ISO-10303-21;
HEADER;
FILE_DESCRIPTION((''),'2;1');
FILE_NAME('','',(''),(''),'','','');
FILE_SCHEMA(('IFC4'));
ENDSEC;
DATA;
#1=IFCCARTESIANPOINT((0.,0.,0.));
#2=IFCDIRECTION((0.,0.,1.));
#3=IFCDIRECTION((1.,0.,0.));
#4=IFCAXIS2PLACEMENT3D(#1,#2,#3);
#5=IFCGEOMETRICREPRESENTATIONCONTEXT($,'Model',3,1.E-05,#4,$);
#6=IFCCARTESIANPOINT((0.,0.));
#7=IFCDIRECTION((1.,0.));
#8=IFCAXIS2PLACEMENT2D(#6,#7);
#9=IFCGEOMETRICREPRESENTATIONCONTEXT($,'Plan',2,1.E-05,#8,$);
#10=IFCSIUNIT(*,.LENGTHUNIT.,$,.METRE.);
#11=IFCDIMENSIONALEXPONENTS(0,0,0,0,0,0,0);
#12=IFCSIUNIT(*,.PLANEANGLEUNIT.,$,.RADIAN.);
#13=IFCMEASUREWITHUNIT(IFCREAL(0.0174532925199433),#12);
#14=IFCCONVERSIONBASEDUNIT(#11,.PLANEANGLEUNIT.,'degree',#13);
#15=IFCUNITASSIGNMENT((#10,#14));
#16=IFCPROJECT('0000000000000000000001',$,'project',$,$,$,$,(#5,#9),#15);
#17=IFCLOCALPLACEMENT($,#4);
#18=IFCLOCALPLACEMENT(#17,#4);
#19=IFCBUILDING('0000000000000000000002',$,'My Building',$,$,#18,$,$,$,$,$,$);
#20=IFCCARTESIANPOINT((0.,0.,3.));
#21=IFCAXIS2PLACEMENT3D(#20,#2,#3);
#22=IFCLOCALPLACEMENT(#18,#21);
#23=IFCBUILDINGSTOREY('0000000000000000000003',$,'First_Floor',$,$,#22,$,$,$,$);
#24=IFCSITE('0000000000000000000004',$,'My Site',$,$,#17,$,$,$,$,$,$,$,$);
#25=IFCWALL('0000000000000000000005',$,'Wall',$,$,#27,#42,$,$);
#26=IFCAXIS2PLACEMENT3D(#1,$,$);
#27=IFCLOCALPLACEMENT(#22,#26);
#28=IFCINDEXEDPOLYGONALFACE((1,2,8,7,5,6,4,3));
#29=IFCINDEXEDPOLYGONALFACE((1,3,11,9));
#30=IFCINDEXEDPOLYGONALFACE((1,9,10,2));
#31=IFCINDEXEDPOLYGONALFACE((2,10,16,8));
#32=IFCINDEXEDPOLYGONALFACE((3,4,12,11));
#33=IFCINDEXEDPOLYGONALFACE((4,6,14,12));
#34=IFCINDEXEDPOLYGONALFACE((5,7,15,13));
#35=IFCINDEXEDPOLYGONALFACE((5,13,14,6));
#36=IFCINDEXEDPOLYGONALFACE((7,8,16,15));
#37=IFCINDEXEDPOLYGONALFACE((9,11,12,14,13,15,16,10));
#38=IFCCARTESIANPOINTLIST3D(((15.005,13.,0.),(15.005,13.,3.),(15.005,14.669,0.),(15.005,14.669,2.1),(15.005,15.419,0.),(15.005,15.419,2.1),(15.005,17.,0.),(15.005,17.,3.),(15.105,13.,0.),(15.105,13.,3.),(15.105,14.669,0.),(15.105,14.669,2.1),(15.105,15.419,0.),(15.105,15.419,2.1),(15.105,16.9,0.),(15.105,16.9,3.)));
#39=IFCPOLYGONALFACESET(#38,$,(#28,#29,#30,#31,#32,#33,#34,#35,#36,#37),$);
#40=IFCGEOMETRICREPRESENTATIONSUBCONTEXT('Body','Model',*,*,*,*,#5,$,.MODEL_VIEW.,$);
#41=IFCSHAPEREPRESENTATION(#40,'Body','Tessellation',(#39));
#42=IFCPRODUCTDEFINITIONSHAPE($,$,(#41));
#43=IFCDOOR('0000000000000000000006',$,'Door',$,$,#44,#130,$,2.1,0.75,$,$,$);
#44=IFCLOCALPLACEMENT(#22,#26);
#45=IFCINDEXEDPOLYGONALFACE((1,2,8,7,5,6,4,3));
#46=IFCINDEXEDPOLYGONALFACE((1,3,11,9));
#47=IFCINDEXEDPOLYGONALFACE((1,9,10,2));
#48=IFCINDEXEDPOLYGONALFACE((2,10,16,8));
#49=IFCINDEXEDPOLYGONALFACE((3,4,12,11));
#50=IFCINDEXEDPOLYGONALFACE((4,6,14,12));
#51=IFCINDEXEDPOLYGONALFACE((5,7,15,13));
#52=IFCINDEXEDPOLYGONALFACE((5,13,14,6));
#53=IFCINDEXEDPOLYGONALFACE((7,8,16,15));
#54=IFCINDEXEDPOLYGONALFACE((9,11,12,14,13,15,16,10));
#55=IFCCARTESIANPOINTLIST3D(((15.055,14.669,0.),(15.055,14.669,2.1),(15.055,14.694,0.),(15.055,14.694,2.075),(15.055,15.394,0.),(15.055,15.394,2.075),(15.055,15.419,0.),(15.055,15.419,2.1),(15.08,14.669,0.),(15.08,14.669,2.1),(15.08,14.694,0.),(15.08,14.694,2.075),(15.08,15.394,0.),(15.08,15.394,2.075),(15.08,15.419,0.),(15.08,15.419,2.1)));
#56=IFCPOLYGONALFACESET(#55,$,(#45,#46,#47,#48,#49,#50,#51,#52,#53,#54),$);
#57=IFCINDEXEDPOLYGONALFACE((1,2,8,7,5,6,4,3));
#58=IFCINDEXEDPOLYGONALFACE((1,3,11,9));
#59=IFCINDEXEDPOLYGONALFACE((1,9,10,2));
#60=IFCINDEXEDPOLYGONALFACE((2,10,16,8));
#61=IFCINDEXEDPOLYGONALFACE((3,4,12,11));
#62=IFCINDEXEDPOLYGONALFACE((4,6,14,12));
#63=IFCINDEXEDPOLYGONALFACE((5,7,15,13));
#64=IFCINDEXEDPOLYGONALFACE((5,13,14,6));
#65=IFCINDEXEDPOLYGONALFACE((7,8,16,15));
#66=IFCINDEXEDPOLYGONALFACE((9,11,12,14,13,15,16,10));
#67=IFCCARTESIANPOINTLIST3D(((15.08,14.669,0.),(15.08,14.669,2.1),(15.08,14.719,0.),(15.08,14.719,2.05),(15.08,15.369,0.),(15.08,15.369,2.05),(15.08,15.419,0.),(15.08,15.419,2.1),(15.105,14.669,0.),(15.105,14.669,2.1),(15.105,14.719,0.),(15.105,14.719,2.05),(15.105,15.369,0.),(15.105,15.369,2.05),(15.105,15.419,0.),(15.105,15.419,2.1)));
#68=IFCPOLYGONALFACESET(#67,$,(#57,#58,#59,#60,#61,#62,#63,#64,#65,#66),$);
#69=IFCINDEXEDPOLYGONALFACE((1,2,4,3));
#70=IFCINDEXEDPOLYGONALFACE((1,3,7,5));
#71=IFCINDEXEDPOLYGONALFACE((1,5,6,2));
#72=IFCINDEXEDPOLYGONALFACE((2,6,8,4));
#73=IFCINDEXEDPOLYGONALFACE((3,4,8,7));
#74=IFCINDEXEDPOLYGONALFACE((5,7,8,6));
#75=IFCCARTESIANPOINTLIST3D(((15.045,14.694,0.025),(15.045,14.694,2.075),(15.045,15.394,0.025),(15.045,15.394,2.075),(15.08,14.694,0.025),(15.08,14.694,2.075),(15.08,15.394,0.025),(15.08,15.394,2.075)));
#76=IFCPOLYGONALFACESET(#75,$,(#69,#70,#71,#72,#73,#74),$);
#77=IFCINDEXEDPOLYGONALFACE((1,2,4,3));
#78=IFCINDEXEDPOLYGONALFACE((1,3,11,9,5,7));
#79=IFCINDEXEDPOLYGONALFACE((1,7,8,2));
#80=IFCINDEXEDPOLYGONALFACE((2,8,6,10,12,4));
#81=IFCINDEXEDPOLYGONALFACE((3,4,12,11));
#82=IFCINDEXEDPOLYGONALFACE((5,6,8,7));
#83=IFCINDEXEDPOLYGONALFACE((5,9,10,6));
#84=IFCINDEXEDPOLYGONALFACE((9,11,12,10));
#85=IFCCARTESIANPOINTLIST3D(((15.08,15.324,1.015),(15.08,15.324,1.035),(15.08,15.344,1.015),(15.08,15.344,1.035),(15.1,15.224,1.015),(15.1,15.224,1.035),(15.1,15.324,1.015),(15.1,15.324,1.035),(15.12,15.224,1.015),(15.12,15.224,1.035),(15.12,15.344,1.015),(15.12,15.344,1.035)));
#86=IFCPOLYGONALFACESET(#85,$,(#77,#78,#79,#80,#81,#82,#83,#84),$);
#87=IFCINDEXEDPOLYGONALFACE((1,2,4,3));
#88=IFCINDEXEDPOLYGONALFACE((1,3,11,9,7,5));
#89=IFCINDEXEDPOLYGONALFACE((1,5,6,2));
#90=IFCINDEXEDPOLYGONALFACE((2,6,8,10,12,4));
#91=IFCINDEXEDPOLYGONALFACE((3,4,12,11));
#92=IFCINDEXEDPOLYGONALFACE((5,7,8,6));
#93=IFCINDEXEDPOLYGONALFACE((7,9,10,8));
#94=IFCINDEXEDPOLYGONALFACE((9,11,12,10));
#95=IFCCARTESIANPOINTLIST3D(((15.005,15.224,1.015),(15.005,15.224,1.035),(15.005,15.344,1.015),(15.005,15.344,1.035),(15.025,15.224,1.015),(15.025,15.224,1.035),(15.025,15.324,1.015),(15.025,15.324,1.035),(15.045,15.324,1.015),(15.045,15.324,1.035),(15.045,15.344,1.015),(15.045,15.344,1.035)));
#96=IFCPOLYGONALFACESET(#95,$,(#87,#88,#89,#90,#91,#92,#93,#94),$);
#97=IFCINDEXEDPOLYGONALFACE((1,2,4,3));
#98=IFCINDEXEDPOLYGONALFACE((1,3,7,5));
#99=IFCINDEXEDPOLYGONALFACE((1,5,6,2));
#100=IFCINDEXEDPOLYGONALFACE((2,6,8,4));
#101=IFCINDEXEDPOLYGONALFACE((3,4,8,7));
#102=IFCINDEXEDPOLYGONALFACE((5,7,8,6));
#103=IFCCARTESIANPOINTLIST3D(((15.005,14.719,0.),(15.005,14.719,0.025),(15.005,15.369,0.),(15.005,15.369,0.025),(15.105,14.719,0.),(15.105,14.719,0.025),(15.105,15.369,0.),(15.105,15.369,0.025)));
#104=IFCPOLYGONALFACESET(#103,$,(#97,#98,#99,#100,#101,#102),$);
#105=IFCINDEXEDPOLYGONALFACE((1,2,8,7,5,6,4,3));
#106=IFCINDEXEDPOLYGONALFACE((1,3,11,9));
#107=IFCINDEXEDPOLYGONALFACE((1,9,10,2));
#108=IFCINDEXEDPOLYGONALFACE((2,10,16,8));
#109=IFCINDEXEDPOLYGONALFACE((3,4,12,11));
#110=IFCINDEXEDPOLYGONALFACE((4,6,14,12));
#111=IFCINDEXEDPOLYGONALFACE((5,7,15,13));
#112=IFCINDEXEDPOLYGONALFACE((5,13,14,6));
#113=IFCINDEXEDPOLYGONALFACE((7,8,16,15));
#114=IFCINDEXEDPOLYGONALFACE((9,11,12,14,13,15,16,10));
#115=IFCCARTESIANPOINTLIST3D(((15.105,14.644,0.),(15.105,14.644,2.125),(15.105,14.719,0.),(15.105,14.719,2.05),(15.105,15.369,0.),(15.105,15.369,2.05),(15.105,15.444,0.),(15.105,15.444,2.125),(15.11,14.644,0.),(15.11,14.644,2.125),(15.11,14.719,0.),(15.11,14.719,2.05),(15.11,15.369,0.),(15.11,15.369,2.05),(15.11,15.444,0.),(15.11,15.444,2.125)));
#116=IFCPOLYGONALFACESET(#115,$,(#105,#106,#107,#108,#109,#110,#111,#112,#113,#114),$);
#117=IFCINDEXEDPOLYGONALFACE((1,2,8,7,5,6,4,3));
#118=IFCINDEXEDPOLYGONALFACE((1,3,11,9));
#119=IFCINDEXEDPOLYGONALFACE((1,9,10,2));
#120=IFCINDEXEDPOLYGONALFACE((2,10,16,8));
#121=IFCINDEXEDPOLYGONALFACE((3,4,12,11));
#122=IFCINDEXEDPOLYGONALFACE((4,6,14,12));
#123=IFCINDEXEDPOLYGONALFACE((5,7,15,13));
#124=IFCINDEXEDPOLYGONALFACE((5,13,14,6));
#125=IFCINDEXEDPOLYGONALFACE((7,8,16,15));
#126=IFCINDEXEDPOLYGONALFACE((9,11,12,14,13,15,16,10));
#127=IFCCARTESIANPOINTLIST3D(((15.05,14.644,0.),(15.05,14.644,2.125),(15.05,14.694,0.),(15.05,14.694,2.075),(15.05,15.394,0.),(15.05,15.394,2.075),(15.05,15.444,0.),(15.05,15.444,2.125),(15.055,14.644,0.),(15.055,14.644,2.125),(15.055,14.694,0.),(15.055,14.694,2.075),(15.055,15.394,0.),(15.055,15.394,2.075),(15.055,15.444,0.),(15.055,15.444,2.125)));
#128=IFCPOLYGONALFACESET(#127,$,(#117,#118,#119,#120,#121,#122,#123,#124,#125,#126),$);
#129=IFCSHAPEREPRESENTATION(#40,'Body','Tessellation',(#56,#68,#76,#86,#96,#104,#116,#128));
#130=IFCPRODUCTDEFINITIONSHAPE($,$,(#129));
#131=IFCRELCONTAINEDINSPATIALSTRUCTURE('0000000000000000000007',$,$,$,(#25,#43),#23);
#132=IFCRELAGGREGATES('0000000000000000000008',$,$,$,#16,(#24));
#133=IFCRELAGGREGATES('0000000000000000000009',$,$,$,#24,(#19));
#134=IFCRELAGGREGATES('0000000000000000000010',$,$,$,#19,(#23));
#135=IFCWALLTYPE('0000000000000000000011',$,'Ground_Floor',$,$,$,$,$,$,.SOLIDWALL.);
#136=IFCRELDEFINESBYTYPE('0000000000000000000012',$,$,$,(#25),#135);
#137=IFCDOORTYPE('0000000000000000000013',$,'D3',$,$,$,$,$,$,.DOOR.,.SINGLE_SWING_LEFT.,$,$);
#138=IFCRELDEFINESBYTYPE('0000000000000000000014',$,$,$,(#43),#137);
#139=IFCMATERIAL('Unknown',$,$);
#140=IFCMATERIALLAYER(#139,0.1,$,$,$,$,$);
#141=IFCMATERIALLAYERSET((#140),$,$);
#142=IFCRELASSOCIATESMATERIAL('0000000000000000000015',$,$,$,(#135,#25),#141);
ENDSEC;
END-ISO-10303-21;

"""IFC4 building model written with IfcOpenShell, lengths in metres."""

from ifc_helpers import new_model, entity, si_unit, converted_unit, frame, origin_with_axes, origin_2d_with_axis, place, context, subcontext, project, spatial, line, indexed_curve, outline, extrude, shape, source, transform, mapped, material, layer, layer_set, layer_usage, type_object, type_shapes, element, fill, save


model = new_model("IFC4")

# Units and contexts
model_context = context("Model", 3, precision=1e-05, world=origin_with_axes())
plan_context = context("Plan", 2, precision=1e-05, world=origin_2d_with_axis())
body_context_1 = subcontext(model_context, "Body", "Model", "MODEL_VIEW")
body_context_2 = subcontext(plan_context, "Body", "Plan", "PLAN_VIEW")
ifc_project = project(units=[si_unit("LENGTHUNIT", "METRE"), converted_unit("PLANEANGLEUNIT", "degree", entity("IfcReal", 0.0174532925199433), si_unit("PLANEANGLEUNIT", "RADIAN"), dimensions=[0, 0, 0, 0, 0, 0, 0])], contexts=[model_context, plan_context])

# Site, building, storey
site_placement = place(None, origin_with_axes())
site = spatial("IfcSite", under=ifc_project, at=site_placement, Name="My Site")
building_placement = place(site_placement, origin_with_axes())
building = spatial("IfcBuilding", under=site, at=building_placement, Name="My Building")
storey_placement = place(building_placement, frame((0.0, 0.0, 3.0), z_axis=(0.0, 0.0, 1.0), x_axis=(1.0, 0.0, 0.0)))
storey = spatial("IfcBuildingStorey", under=building, at=storey_placement, Name="First_Floor")

# Shared definitions
ifc_material = material(Name="Unknown")

# Shared definitions
ifc_layer = layer(ifc_material, 0.1)
ifc_layer_set = layer_set([ifc_layer])
wall_type = type_object("IfcWallType", Name="Ground_Floor", PredefinedType="SOLIDWALL", material=ifc_layer_set)

# Wall, opening, door
ifc_layer_usage_1 = layer_usage(ifc_layer_set, "AXIS2", "POSITIVE", 0.0)
wall_1_placement = place(storey_placement, frame((15.005, 17.0, 0.0), z_axis=(0.0, 0.0, 1.0), x_axis=(0.0, -1.0, 0.0)))
wall_1 = element("IfcWall", 1, at=wall_1_placement, inside=storey, type_object=wall_type, material=ifc_layer_usage_1, Name="Wall", context=body_context_1, shape_type="SweptSolid", body=[
    extrude(outline(indexed_curve([(0.0, 0.0), (0.1, 0.1), (4.0, 0.1), (4.0, 0.0)], segments=[line(1, 2, 3, 4, 1)])), origin_with_axes(), (0.0, 0.0, 1.0), 3.0),
])
shared_shape_1 = source(origin_with_axes(), body_context_1, "Body", "SweptSolid", [
    extrude(outline(indexed_curve([(0.0, 0.0), (0.75, 0.0), (0.75, 2.1), (0.0, 2.1)], segments=[line(1, 2, 3, 4, 1)])), frame((0.0, -0.6, 0.0), z_axis=(0.0, -1.0, 0.0), x_axis=(1.0, 0.0, 0.0)), (0.0, 0.0, -1.0), 1.2),
])
opening_1_placement = place(wall_1_placement, frame((2.331, 0.1, 0.0), z_axis=(0.0, 0.0, 1.0), x_axis=(-1.0, 0.0, 0.0)))
opening_1 = element("IfcOpeningElement", 2, at=opening_1_placement, cuts=wall_1, PredefinedType="OPENING", context=body_context_1, shape_type="MappedRepresentation", body=[
    mapped(shared_shape_1, transform((0.0, 0.0, 0.0), x_axis=(1.0, 0.0, 0.0), y_axis=(0.0, 1.0, 0.0), z_axis=(0.0, 0.0, 1.0), scale=1.0)),
])
door_type_1 = type_object("IfcDoorType", Name="D3", OperationType="SINGLE_SWING_LEFT", PredefinedType="DOOR")
shared_shape_2 = source(origin_with_axes(), body_context_1, "Body", "SweptSolid", [
    extrude(outline(indexed_curve([(0.0, 0.0), (0.0, 2.1), (0.75, 2.1), (0.75, 0.0), (0.725, 0.0), (0.725, 2.075), (0.025, 2.075), (0.025, 0.0)], segments=[line(1, 2, 3, 4, 5, 6, 7, 8, 1)])), frame((0.0, 0.025, 0.0), z_axis=(0.0, -1.0, 0.0), x_axis=(1.0, 0.0, 0.0)), (0.0, 0.0, -1.0), 0.025),
    extrude(outline(indexed_curve([(0.0, 0.0), (0.0, 2.1), (0.75, 2.1), (0.75, 0.0), (0.7, 0.0), (0.7, 2.05), (0.05, 2.05), (0.05, 0.0)], segments=[line(1, 2, 3, 4, 5, 6, 7, 8, 1)])), frame((0.0, 0.0, 0.0), z_axis=(0.0, -1.0, 0.0), x_axis=(1.0, 0.0, 0.0)), (0.0, 0.0, -1.0), 0.025),
    extrude(outline(indexed_curve([(0.0, 0.0), (0.7, 0.0), (0.7, 0.035), (0.0, 0.035)], segments=[line(1, 2, 3, 4, 1)])), frame((0.025, 0.025, 0.025), z_axis=(0.0, 0.0, 1.0), x_axis=(1.0, 0.0, 0.0)), (0.0, 0.0, 1.0), 2.05),
    extrude(outline(indexed_curve([(0.0, 0.0), (0.0, -0.04), (-0.12, -0.04), (-0.12, -0.02), (-0.02, -0.02), (-0.02, 0.0)], segments=[line(1, 2, 3, 4, 5, 6, 1)])), frame((0.675, 0.025, 1.015), z_axis=(0.0, 0.0, 1.0), x_axis=(1.0, 0.0, 0.0)), (0.0, 0.0, 1.0), 0.02),
    extrude(outline(indexed_curve([(0.0, 0.0), (0.0, 0.04), (-0.12, 0.04), (-0.12, 0.02), (-0.02, 0.02), (-0.02, 0.0)], segments=[line(1, 2, 3, 4, 5, 6, 1)])), frame((0.675, 0.06, 1.015), z_axis=(0.0, 0.0, 1.0), x_axis=(1.0, 0.0, 0.0)), (0.0, 0.0, 1.0), 0.02),
    extrude(outline(indexed_curve([(0.0, 0.0), (0.65, 0.0), (0.65, 0.1), (0.0, 0.1)], segments=[line(1, 2, 3, 4, 1)])), frame((0.05, 0.0, 0.0), z_axis=(0.0, 0.0, 1.0), x_axis=(1.0, 0.0, 0.0)), (0.0, 0.0, 1.0), 0.025),
    extrude(outline(indexed_curve([(0.0, 0.0), (0.0, 2.125), (0.8, 2.125), (0.8, 0.0), (0.725, 0.0), (0.725, 2.05), (0.075, 2.05), (0.075, 0.0)], segments=[line(1, 2, 3, 4, 5, 6, 7, 8, 1)])), frame((-0.025, -0.005, 0.0), z_axis=(0.0, -1.0, 0.0), x_axis=(1.0, 0.0, 0.0)), (0.0, 0.0, -1.0), 0.005),
    extrude(outline(indexed_curve([(0.0, 0.0), (0.0, 2.125), (0.8, 2.125), (0.8, 0.0), (0.75, 0.0), (0.75, 2.075), (0.05, 2.075), (0.05, 0.0)], segments=[line(1, 2, 3, 4, 5, 6, 7, 8, 1)])), frame((-0.025, 0.05, 0.0), z_axis=(0.0, -1.0, 0.0), x_axis=(1.0, 0.0, 0.0)), (0.0, 0.0, -1.0), 0.005),
])
shared_shape_3 = source(origin_with_axes(), body_context_2, "Body", "Curve2D", [
    entity("IfcIndexedPolyCurve", entity("IfcCartesianPointList2D", [[0.0, 0.0], [0.0, 0.05], [0.025, 0.05], [0.025, 0.025], [0.05, 0.025], [0.05, 0.0]]), [entity("IfcLineIndex", [1, 2, 3, 4, 5, 6, 1])]),
    entity("IfcIndexedPolyCurve", entity("IfcCartesianPointList2D", [[0.75, 0.0], [0.75, 0.05], [0.725, 0.05], [0.725, 0.025], [0.7, 0.025], [0.7, 0.0]]), [entity("IfcLineIndex", [1, 2, 3, 4, 5, 6, 1])]),
    entity("IfcTrimmedCurve", entity("IfcEllipse", entity("IfcAxis2Placement2D", entity("IfcCartesianPoint", [0.06, 0.05]), entity("IfcDirection", [1.0, 0.0])), 0.665, 0.7), [entity("IfcCartesianPoint", [0.725, 0.05])], [entity("IfcCartesianPoint", [0.06, 0.75])], True, "CARTESIAN"),
    entity("IfcIndexedPolyCurve", entity("IfcCartesianPointList2D", [[0.025, 0.05], [0.06, 0.05], [0.06, 0.75], [0.025, 0.75]]), [entity("IfcLineIndex", [1, 2, 3, 4, 1])]),
])
type_shapes(door_type_1, [shared_shape_2, shared_shape_3])
door_1_placement = place(opening_1_placement, frame((0.0, 0.0, 0.0), z_axis=(0.0, 0.0, 1.0), x_axis=(1.0, 0.0, 0.0)))
door_1 = element("IfcDoor", 3, at=door_1_placement, inside=storey, type_object=door_type_1, Name="Door", OverallHeight=2.1, OverallWidth=0.75, shapes=[
    shape(body_context_1, "Body", "MappedRepresentation", [mapped(shared_shape_2, transform((0.0, 0.0, 0.0), x_axis=(1.0, 0.0, 0.0), y_axis=(0.0, 1.0, 0.0), z_axis=(0.0, 0.0, 1.0), scale=1.0))]),
    shape(body_context_2, "Body", "MappedRepresentation", [mapped(shared_shape_3, transform((0.0, 0.0, 0.0), x_axis=(1.0, 0.0, 0.0), y_axis=(0.0, 1.0, 0.0), z_axis=(0.0, 0.0, 1.0), scale=1.0))]),
])
fill(opening_1, door_1)

save(model, "model.ifc")
